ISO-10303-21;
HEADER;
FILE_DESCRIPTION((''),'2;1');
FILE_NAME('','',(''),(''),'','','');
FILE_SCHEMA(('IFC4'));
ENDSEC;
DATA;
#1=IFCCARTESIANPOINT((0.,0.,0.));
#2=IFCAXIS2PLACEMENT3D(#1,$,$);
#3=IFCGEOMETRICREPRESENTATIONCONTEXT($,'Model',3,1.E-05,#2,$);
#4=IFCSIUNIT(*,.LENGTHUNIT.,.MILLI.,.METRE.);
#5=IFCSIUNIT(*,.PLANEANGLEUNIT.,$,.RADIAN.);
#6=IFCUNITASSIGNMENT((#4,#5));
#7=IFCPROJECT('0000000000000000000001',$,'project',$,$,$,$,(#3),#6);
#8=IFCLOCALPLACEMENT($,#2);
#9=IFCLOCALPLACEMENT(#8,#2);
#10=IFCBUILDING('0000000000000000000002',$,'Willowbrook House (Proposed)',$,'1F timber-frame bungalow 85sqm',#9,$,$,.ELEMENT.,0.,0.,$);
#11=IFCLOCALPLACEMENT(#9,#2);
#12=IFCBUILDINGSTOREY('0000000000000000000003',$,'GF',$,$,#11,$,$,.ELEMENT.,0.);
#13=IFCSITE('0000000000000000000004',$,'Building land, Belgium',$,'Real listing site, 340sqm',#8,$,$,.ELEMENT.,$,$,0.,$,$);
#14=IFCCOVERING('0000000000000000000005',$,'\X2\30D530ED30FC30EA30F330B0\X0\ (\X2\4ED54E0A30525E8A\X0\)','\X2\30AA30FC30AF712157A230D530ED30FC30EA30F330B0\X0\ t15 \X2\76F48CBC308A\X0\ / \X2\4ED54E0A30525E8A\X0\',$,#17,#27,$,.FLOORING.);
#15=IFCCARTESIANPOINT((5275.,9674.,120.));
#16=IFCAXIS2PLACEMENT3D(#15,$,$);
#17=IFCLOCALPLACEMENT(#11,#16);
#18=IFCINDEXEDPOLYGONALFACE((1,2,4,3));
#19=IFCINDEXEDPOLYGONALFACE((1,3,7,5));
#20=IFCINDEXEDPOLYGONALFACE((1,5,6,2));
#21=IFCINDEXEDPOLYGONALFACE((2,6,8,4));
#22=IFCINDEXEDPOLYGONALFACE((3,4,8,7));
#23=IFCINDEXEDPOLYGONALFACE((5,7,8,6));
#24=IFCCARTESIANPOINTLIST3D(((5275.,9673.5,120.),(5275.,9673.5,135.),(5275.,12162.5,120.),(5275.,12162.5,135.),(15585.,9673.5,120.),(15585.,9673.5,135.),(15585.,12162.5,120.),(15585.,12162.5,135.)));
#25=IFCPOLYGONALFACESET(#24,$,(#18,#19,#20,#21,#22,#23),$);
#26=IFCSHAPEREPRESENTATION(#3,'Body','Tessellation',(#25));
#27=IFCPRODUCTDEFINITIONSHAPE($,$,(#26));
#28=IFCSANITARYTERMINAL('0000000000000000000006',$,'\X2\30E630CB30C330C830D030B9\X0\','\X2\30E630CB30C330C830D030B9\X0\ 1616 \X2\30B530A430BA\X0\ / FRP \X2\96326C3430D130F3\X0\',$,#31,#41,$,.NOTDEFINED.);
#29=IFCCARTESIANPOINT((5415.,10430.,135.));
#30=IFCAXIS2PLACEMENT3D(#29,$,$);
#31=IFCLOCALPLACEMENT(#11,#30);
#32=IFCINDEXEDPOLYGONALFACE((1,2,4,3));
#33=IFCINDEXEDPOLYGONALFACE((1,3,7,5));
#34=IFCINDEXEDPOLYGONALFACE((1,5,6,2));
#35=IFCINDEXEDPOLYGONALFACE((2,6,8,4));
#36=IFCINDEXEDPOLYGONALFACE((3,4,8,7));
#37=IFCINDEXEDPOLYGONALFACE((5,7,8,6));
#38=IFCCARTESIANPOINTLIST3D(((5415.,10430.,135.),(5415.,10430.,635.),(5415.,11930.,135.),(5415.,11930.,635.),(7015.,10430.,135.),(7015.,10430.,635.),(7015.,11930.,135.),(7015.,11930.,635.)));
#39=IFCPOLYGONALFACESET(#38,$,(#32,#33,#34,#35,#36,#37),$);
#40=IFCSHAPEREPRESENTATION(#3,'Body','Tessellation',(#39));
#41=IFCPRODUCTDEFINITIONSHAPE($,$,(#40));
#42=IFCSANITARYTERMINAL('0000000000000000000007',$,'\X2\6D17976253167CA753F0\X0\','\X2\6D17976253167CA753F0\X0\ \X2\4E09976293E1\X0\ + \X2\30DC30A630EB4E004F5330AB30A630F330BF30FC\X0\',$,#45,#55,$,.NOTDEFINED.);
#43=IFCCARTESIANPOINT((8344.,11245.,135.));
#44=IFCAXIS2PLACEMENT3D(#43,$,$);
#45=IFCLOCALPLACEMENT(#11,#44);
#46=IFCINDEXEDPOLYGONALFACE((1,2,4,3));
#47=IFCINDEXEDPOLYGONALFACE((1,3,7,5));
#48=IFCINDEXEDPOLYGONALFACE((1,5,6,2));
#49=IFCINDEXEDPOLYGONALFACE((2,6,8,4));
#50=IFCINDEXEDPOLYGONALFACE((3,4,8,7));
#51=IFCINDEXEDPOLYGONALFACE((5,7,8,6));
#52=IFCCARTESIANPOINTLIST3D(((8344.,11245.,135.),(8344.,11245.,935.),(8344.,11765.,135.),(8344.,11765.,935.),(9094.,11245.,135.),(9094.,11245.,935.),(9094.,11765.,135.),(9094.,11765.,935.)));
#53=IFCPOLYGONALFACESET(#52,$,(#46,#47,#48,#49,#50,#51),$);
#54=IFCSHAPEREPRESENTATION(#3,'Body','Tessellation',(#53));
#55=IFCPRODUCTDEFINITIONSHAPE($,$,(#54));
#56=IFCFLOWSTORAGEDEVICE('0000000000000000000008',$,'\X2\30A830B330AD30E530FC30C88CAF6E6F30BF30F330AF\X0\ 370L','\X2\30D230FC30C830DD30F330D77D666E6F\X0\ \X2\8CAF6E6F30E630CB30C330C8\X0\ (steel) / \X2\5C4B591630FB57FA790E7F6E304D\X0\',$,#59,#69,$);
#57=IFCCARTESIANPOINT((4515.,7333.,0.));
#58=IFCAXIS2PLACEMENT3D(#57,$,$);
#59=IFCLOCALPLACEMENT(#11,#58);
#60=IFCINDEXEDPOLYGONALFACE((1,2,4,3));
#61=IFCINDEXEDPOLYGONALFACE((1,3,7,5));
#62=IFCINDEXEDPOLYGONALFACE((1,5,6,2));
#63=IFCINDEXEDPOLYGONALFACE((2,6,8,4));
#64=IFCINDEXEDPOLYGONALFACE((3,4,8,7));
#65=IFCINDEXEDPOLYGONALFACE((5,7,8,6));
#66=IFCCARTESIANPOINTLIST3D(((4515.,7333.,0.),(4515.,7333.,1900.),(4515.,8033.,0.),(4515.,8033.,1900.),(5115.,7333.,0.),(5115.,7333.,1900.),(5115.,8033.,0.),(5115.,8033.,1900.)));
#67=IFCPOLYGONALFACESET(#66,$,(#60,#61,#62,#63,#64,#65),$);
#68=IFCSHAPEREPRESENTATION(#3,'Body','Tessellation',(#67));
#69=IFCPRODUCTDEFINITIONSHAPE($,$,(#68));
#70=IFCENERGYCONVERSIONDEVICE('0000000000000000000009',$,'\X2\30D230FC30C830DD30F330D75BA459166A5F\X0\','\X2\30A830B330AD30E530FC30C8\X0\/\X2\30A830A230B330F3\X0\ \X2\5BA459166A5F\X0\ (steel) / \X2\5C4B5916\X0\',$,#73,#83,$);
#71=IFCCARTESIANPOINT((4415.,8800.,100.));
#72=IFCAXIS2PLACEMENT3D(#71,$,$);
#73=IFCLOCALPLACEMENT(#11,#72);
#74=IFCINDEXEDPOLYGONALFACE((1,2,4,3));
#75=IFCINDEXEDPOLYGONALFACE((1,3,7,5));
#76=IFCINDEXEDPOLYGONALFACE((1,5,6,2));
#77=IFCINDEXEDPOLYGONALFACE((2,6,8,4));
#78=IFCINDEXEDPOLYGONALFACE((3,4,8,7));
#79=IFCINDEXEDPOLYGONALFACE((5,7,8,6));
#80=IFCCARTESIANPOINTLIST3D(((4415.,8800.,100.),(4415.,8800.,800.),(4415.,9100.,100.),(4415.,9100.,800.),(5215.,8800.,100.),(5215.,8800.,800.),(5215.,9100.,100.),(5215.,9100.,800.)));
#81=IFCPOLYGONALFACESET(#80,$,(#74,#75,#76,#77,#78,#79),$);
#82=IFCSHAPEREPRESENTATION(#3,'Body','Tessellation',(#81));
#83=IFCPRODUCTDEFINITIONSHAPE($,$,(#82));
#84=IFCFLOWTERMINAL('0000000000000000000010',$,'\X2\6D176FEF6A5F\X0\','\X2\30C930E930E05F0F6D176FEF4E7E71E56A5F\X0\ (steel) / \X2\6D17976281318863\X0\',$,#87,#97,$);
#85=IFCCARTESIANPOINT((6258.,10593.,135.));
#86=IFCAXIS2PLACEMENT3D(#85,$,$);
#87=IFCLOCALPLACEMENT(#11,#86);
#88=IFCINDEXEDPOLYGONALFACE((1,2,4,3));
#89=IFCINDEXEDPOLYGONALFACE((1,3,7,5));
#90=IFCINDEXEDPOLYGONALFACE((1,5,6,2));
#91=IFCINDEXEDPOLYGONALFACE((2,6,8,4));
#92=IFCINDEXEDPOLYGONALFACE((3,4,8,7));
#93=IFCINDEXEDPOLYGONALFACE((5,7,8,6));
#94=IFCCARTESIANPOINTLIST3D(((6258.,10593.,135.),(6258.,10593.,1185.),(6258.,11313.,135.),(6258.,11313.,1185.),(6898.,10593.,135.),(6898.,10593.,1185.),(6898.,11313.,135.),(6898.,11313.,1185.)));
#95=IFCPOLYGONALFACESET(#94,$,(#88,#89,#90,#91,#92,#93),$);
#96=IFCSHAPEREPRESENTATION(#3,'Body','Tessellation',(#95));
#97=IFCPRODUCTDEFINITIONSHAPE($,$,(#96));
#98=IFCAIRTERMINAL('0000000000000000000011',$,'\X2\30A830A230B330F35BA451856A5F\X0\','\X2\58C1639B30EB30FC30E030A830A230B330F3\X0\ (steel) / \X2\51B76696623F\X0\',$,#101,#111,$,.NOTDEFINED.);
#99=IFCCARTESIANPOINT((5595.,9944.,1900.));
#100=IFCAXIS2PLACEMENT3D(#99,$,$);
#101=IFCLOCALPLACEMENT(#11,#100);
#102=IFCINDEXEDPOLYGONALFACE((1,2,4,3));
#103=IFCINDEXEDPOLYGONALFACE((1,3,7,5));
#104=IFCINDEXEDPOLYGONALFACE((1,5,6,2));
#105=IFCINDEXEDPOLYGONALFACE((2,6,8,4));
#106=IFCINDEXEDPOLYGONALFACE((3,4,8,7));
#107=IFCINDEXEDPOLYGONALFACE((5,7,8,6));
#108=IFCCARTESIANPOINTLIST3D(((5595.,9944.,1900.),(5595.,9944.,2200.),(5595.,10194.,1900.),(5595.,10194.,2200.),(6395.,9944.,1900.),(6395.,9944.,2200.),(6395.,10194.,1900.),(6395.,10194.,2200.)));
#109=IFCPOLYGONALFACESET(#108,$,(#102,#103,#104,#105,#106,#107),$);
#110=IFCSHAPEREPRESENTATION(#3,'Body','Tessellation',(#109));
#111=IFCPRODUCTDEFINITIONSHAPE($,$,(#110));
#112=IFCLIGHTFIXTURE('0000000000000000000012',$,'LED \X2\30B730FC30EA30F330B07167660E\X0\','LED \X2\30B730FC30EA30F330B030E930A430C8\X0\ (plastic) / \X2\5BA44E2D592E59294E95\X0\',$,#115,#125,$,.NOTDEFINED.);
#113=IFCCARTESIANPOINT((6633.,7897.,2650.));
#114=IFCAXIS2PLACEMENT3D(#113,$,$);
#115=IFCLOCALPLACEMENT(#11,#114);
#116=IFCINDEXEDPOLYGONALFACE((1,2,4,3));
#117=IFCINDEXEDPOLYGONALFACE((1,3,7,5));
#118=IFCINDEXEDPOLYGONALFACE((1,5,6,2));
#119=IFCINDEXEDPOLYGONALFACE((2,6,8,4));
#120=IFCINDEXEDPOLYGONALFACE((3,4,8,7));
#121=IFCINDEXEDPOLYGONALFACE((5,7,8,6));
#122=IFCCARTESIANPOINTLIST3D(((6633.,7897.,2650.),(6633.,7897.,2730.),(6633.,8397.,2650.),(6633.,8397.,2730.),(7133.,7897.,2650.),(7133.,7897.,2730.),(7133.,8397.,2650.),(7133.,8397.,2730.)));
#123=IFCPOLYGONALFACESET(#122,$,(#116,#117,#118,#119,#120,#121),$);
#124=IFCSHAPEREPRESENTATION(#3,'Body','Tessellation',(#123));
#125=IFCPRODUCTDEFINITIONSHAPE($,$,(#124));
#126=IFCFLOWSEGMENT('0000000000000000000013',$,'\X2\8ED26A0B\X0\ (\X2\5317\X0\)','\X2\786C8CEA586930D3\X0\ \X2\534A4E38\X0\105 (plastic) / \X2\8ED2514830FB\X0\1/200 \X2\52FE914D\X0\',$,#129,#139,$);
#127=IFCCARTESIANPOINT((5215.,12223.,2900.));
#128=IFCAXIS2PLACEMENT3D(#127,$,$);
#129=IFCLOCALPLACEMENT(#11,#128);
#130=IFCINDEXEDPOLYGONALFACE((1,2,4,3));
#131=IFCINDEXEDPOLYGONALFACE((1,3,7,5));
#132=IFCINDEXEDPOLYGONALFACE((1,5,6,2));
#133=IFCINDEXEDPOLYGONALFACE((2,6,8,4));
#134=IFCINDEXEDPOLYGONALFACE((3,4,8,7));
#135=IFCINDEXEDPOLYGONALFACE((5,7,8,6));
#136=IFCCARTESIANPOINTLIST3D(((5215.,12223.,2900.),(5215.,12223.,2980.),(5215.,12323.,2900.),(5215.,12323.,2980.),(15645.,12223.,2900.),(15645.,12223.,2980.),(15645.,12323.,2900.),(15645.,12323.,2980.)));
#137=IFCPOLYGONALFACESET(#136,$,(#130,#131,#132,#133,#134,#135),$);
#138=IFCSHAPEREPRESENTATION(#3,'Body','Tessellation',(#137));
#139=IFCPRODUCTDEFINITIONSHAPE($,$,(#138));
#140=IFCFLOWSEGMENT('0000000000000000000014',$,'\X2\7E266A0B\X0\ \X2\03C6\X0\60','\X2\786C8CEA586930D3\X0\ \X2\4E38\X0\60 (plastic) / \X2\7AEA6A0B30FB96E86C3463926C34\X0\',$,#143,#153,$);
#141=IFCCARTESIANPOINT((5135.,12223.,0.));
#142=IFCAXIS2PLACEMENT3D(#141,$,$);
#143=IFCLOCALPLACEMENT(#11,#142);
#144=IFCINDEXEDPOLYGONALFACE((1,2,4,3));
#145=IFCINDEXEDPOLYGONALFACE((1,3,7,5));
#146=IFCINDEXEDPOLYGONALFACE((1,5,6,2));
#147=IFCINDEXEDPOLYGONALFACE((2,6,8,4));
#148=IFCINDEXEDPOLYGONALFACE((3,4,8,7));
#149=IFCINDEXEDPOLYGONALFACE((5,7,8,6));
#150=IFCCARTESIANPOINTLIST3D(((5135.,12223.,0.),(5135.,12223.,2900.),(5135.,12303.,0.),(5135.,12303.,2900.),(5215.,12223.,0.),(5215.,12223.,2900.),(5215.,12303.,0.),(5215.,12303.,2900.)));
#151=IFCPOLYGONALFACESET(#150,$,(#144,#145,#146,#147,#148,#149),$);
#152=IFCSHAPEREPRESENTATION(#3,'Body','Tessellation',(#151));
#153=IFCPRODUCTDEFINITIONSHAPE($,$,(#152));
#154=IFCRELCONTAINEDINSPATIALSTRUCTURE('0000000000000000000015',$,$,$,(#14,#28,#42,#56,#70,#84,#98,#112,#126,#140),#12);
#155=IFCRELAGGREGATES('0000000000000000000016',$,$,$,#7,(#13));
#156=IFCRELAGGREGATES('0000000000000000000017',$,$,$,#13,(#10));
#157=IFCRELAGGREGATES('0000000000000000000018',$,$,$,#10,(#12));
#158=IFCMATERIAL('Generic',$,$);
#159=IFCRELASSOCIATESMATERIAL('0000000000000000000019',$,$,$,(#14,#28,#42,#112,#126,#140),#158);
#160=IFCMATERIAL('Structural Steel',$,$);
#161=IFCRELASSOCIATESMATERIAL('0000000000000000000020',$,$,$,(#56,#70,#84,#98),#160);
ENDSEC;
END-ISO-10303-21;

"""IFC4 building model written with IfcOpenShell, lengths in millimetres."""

from ifc_helpers import new_model, si_unit, frame, frame_2d, origin, place, context, project, spatial, rectangle, extrude, material, element, save


model = new_model("IFC4")

# Units and contexts
model_context = context("Model", 3, precision=1e-05, world=origin())
ifc_project = project(units=[si_unit("LENGTHUNIT", "METRE", prefix="MILLI"), si_unit("PLANEANGLEUNIT", "RADIAN")], contexts=[model_context])

# Site, building, storey
site_placement = place(None, origin())
site = spatial("IfcSite", under=ifc_project, at=site_placement, Name="Building land, Belgium", ObjectType="Real listing site, 340sqm", CompositionType="ELEMENT", RefElevation=0.0)
building_placement = place(site_placement, origin())
building = spatial("IfcBuilding", under=site, at=building_placement, Name="Willowbrook House (Proposed)", ObjectType="1F timber-frame bungalow 85sqm", CompositionType="ELEMENT", ElevationOfRefHeight=0.0, ElevationOfTerrain=0.0)
storey_placement = place(building_placement, origin())
storey = spatial("IfcBuildingStorey", under=building, at=storey_placement, Name="GF", CompositionType="ELEMENT", Elevation=0.0)

# Shared definitions
ifc_material_1 = material(Name="Structural Steel")

# Covering
ifc_material_2 = material(Name="Generic")
covering_1_placement = place(storey_placement, frame((5275.0, 9674.0, 120.0)))
element("IfcCovering", 1, at=covering_1_placement, inside=storey, material=ifc_material_2, Name="フローリング (仕上げ床)", Description="オーク無垢フローリング t15 直貼り / 仕上げ床", PredefinedType="FLOORING", context=model_context, shape_type="SweptSolid", body=[
    extrude(rectangle(XDim=10310.0, YDim=2489.0, at=frame_2d((5155.0, 1244.0))), frame((5275.0, 9674.0, 120.0)), (0.0, 0.0, 1.0), 15.0),
])

# Sanitary terminals
sanitary_terminal_1_placement = place(storey_placement, frame((5415.0, 10430.0, 135.0)))
element("IfcSanitaryTerminal", 2, at=sanitary_terminal_1_placement, inside=storey, material=ifc_material_2, Name="ユニットバス", Description="ユニットバス 1616 サイズ / FRP 防水パン", PredefinedType="NOTDEFINED", context=model_context, shape_type="SweptSolid", body=[
    extrude(rectangle(XDim=1600.0, YDim=1500.0, at=frame_2d((800.0, 750.0))), frame((5415.0, 10430.0, 135.0)), (0.0, 0.0, 1.0), 500.0),
])
sanitary_terminal_2_placement = place(storey_placement, frame((8344.0, 11245.0, 135.0)))
element("IfcSanitaryTerminal", 3, at=sanitary_terminal_2_placement, inside=storey, material=ifc_material_2, Name="洗面化粧台", Description="洗面化粧台 三面鏡 + ボウル一体カウンター", PredefinedType="NOTDEFINED", context=model_context, shape_type="SweptSolid", body=[
    extrude(rectangle(XDim=750.0, YDim=520.0, at=frame_2d((375.0, 260.0))), frame((8344.0, 11245.0, 135.0)), (0.0, 0.0, 1.0), 800.0),
])

# Flow storage device
flow_storage_device_placement = place(storey_placement, frame((4515.0, 7333.0, 0.0)))
element("IfcFlowStorageDevice", 4, at=flow_storage_device_placement, inside=storey, material=ifc_material_1, Name="エコキュート貯湯タンク 370L", Description="ヒートポンプ給湯 貯湯ユニット (steel) / 屋外・基礎置き", context=model_context, shape_type="SweptSolid", body=[
    extrude(rectangle(XDim=600.0, YDim=700.0, at=frame_2d((300.0, 350.0))), frame((4515.0, 7333.0, 0.0)), (0.0, 0.0, 1.0), 1900.0),
])

# Energy conversion device
energy_conversion_device_placement = place(storey_placement, frame((4415.0, 8800.0, 100.0)))
element("IfcEnergyConversionDevice", 5, at=energy_conversion_device_placement, inside=storey, material=ifc_material_1, Name="ヒートポンプ室外機", Description="エコキュート/エアコン 室外機 (steel) / 屋外", context=model_context, shape_type="SweptSolid", body=[
    extrude(rectangle(XDim=800.0, YDim=300.0, at=frame_2d((400.0, 150.0))), frame((4415.0, 8800.0, 100.0)), (0.0, 0.0, 1.0), 700.0),
])

# Flow terminal
flow_terminal_placement = place(storey_placement, frame((6258.0, 10593.0, 135.0)))
element("IfcFlowTerminal", 6, at=flow_terminal_placement, inside=storey, material=ifc_material_1, Name="洗濯機", Description="ドラム式洗濯乾燥機 (steel) / 洗面脱衣", context=model_context, shape_type="SweptSolid", body=[
    extrude(rectangle(XDim=640.0, YDim=720.0, at=frame_2d((320.0, 360.0))), frame((6258.0, 10593.0, 135.0)), (0.0, 0.0, 1.0), 1050.0),
])

# Air terminal
air_terminal_placement = place(storey_placement, frame((5595.0, 9944.0, 1900.0)))
element("IfcAirTerminal", 7, at=air_terminal_placement, inside=storey, material=ifc_material_1, Name="エアコン室内機", Description="壁掛ルームエアコン (steel) / 冷暖房", PredefinedType="NOTDEFINED", context=model_context, shape_type="SweptSolid", body=[
    extrude(rectangle(XDim=800.0, YDim=250.0, at=frame_2d((400.0, 125.0))), frame((5595.0, 9944.0, 1900.0)), (0.0, 0.0, 1.0), 300.0),
])

# Light fixture
light_fixture_placement = place(storey_placement, frame((6633.0, 7897.0, 2650.0)))
element("IfcLightFixture", 8, at=light_fixture_placement, inside=storey, material=ifc_material_2, Name="LED シーリング照明", Description="LED シーリングライト (plastic) / 室中央天井", PredefinedType="NOTDEFINED", context=model_context, shape_type="SweptSolid", body=[
    extrude(rectangle(XDim=500.0, YDim=500.0, at=frame_2d((250.0, 250.0))), frame((6633.0, 7897.0, 2650.0)), (0.0, 0.0, 1.0), 80.0),
])

# Flow segments
flow_segment_1_placement = place(storey_placement, frame((5215.0, 12223.0, 2900.0)))
element("IfcFlowSegment", 9, at=flow_segment_1_placement, inside=storey, material=ifc_material_2, Name="軒樋 (北)", Description="硬質塩ビ 半丸105 (plastic) / 軒先・1/200 勾配", context=model_context, shape_type="SweptSolid", body=[
    extrude(rectangle(XDim=10430.0, YDim=100.0, at=frame_2d((5215.0, 50.0))), frame((5215.0, 12223.0, 2900.0)), (0.0, 0.0, 1.0), 80.0),
])
flow_segment_2_placement = place(storey_placement, frame((5135.0, 12223.0, 0.0)))
element("IfcFlowSegment", 10, at=flow_segment_2_placement, inside=storey, material=ifc_material_2, Name="縦樋 φ60", Description="硬質塩ビ 丸60 (plastic) / 竪樋・雨水排水", context=model_context, shape_type="SweptSolid", body=[
    extrude(rectangle(XDim=80.0, YDim=80.0, at=frame_2d((40.0, 40.0))), frame((5135.0, 12223.0, 0.0)), (0.0, 0.0, 1.0), 2900.0),
])

save(model, "model.ifc")
